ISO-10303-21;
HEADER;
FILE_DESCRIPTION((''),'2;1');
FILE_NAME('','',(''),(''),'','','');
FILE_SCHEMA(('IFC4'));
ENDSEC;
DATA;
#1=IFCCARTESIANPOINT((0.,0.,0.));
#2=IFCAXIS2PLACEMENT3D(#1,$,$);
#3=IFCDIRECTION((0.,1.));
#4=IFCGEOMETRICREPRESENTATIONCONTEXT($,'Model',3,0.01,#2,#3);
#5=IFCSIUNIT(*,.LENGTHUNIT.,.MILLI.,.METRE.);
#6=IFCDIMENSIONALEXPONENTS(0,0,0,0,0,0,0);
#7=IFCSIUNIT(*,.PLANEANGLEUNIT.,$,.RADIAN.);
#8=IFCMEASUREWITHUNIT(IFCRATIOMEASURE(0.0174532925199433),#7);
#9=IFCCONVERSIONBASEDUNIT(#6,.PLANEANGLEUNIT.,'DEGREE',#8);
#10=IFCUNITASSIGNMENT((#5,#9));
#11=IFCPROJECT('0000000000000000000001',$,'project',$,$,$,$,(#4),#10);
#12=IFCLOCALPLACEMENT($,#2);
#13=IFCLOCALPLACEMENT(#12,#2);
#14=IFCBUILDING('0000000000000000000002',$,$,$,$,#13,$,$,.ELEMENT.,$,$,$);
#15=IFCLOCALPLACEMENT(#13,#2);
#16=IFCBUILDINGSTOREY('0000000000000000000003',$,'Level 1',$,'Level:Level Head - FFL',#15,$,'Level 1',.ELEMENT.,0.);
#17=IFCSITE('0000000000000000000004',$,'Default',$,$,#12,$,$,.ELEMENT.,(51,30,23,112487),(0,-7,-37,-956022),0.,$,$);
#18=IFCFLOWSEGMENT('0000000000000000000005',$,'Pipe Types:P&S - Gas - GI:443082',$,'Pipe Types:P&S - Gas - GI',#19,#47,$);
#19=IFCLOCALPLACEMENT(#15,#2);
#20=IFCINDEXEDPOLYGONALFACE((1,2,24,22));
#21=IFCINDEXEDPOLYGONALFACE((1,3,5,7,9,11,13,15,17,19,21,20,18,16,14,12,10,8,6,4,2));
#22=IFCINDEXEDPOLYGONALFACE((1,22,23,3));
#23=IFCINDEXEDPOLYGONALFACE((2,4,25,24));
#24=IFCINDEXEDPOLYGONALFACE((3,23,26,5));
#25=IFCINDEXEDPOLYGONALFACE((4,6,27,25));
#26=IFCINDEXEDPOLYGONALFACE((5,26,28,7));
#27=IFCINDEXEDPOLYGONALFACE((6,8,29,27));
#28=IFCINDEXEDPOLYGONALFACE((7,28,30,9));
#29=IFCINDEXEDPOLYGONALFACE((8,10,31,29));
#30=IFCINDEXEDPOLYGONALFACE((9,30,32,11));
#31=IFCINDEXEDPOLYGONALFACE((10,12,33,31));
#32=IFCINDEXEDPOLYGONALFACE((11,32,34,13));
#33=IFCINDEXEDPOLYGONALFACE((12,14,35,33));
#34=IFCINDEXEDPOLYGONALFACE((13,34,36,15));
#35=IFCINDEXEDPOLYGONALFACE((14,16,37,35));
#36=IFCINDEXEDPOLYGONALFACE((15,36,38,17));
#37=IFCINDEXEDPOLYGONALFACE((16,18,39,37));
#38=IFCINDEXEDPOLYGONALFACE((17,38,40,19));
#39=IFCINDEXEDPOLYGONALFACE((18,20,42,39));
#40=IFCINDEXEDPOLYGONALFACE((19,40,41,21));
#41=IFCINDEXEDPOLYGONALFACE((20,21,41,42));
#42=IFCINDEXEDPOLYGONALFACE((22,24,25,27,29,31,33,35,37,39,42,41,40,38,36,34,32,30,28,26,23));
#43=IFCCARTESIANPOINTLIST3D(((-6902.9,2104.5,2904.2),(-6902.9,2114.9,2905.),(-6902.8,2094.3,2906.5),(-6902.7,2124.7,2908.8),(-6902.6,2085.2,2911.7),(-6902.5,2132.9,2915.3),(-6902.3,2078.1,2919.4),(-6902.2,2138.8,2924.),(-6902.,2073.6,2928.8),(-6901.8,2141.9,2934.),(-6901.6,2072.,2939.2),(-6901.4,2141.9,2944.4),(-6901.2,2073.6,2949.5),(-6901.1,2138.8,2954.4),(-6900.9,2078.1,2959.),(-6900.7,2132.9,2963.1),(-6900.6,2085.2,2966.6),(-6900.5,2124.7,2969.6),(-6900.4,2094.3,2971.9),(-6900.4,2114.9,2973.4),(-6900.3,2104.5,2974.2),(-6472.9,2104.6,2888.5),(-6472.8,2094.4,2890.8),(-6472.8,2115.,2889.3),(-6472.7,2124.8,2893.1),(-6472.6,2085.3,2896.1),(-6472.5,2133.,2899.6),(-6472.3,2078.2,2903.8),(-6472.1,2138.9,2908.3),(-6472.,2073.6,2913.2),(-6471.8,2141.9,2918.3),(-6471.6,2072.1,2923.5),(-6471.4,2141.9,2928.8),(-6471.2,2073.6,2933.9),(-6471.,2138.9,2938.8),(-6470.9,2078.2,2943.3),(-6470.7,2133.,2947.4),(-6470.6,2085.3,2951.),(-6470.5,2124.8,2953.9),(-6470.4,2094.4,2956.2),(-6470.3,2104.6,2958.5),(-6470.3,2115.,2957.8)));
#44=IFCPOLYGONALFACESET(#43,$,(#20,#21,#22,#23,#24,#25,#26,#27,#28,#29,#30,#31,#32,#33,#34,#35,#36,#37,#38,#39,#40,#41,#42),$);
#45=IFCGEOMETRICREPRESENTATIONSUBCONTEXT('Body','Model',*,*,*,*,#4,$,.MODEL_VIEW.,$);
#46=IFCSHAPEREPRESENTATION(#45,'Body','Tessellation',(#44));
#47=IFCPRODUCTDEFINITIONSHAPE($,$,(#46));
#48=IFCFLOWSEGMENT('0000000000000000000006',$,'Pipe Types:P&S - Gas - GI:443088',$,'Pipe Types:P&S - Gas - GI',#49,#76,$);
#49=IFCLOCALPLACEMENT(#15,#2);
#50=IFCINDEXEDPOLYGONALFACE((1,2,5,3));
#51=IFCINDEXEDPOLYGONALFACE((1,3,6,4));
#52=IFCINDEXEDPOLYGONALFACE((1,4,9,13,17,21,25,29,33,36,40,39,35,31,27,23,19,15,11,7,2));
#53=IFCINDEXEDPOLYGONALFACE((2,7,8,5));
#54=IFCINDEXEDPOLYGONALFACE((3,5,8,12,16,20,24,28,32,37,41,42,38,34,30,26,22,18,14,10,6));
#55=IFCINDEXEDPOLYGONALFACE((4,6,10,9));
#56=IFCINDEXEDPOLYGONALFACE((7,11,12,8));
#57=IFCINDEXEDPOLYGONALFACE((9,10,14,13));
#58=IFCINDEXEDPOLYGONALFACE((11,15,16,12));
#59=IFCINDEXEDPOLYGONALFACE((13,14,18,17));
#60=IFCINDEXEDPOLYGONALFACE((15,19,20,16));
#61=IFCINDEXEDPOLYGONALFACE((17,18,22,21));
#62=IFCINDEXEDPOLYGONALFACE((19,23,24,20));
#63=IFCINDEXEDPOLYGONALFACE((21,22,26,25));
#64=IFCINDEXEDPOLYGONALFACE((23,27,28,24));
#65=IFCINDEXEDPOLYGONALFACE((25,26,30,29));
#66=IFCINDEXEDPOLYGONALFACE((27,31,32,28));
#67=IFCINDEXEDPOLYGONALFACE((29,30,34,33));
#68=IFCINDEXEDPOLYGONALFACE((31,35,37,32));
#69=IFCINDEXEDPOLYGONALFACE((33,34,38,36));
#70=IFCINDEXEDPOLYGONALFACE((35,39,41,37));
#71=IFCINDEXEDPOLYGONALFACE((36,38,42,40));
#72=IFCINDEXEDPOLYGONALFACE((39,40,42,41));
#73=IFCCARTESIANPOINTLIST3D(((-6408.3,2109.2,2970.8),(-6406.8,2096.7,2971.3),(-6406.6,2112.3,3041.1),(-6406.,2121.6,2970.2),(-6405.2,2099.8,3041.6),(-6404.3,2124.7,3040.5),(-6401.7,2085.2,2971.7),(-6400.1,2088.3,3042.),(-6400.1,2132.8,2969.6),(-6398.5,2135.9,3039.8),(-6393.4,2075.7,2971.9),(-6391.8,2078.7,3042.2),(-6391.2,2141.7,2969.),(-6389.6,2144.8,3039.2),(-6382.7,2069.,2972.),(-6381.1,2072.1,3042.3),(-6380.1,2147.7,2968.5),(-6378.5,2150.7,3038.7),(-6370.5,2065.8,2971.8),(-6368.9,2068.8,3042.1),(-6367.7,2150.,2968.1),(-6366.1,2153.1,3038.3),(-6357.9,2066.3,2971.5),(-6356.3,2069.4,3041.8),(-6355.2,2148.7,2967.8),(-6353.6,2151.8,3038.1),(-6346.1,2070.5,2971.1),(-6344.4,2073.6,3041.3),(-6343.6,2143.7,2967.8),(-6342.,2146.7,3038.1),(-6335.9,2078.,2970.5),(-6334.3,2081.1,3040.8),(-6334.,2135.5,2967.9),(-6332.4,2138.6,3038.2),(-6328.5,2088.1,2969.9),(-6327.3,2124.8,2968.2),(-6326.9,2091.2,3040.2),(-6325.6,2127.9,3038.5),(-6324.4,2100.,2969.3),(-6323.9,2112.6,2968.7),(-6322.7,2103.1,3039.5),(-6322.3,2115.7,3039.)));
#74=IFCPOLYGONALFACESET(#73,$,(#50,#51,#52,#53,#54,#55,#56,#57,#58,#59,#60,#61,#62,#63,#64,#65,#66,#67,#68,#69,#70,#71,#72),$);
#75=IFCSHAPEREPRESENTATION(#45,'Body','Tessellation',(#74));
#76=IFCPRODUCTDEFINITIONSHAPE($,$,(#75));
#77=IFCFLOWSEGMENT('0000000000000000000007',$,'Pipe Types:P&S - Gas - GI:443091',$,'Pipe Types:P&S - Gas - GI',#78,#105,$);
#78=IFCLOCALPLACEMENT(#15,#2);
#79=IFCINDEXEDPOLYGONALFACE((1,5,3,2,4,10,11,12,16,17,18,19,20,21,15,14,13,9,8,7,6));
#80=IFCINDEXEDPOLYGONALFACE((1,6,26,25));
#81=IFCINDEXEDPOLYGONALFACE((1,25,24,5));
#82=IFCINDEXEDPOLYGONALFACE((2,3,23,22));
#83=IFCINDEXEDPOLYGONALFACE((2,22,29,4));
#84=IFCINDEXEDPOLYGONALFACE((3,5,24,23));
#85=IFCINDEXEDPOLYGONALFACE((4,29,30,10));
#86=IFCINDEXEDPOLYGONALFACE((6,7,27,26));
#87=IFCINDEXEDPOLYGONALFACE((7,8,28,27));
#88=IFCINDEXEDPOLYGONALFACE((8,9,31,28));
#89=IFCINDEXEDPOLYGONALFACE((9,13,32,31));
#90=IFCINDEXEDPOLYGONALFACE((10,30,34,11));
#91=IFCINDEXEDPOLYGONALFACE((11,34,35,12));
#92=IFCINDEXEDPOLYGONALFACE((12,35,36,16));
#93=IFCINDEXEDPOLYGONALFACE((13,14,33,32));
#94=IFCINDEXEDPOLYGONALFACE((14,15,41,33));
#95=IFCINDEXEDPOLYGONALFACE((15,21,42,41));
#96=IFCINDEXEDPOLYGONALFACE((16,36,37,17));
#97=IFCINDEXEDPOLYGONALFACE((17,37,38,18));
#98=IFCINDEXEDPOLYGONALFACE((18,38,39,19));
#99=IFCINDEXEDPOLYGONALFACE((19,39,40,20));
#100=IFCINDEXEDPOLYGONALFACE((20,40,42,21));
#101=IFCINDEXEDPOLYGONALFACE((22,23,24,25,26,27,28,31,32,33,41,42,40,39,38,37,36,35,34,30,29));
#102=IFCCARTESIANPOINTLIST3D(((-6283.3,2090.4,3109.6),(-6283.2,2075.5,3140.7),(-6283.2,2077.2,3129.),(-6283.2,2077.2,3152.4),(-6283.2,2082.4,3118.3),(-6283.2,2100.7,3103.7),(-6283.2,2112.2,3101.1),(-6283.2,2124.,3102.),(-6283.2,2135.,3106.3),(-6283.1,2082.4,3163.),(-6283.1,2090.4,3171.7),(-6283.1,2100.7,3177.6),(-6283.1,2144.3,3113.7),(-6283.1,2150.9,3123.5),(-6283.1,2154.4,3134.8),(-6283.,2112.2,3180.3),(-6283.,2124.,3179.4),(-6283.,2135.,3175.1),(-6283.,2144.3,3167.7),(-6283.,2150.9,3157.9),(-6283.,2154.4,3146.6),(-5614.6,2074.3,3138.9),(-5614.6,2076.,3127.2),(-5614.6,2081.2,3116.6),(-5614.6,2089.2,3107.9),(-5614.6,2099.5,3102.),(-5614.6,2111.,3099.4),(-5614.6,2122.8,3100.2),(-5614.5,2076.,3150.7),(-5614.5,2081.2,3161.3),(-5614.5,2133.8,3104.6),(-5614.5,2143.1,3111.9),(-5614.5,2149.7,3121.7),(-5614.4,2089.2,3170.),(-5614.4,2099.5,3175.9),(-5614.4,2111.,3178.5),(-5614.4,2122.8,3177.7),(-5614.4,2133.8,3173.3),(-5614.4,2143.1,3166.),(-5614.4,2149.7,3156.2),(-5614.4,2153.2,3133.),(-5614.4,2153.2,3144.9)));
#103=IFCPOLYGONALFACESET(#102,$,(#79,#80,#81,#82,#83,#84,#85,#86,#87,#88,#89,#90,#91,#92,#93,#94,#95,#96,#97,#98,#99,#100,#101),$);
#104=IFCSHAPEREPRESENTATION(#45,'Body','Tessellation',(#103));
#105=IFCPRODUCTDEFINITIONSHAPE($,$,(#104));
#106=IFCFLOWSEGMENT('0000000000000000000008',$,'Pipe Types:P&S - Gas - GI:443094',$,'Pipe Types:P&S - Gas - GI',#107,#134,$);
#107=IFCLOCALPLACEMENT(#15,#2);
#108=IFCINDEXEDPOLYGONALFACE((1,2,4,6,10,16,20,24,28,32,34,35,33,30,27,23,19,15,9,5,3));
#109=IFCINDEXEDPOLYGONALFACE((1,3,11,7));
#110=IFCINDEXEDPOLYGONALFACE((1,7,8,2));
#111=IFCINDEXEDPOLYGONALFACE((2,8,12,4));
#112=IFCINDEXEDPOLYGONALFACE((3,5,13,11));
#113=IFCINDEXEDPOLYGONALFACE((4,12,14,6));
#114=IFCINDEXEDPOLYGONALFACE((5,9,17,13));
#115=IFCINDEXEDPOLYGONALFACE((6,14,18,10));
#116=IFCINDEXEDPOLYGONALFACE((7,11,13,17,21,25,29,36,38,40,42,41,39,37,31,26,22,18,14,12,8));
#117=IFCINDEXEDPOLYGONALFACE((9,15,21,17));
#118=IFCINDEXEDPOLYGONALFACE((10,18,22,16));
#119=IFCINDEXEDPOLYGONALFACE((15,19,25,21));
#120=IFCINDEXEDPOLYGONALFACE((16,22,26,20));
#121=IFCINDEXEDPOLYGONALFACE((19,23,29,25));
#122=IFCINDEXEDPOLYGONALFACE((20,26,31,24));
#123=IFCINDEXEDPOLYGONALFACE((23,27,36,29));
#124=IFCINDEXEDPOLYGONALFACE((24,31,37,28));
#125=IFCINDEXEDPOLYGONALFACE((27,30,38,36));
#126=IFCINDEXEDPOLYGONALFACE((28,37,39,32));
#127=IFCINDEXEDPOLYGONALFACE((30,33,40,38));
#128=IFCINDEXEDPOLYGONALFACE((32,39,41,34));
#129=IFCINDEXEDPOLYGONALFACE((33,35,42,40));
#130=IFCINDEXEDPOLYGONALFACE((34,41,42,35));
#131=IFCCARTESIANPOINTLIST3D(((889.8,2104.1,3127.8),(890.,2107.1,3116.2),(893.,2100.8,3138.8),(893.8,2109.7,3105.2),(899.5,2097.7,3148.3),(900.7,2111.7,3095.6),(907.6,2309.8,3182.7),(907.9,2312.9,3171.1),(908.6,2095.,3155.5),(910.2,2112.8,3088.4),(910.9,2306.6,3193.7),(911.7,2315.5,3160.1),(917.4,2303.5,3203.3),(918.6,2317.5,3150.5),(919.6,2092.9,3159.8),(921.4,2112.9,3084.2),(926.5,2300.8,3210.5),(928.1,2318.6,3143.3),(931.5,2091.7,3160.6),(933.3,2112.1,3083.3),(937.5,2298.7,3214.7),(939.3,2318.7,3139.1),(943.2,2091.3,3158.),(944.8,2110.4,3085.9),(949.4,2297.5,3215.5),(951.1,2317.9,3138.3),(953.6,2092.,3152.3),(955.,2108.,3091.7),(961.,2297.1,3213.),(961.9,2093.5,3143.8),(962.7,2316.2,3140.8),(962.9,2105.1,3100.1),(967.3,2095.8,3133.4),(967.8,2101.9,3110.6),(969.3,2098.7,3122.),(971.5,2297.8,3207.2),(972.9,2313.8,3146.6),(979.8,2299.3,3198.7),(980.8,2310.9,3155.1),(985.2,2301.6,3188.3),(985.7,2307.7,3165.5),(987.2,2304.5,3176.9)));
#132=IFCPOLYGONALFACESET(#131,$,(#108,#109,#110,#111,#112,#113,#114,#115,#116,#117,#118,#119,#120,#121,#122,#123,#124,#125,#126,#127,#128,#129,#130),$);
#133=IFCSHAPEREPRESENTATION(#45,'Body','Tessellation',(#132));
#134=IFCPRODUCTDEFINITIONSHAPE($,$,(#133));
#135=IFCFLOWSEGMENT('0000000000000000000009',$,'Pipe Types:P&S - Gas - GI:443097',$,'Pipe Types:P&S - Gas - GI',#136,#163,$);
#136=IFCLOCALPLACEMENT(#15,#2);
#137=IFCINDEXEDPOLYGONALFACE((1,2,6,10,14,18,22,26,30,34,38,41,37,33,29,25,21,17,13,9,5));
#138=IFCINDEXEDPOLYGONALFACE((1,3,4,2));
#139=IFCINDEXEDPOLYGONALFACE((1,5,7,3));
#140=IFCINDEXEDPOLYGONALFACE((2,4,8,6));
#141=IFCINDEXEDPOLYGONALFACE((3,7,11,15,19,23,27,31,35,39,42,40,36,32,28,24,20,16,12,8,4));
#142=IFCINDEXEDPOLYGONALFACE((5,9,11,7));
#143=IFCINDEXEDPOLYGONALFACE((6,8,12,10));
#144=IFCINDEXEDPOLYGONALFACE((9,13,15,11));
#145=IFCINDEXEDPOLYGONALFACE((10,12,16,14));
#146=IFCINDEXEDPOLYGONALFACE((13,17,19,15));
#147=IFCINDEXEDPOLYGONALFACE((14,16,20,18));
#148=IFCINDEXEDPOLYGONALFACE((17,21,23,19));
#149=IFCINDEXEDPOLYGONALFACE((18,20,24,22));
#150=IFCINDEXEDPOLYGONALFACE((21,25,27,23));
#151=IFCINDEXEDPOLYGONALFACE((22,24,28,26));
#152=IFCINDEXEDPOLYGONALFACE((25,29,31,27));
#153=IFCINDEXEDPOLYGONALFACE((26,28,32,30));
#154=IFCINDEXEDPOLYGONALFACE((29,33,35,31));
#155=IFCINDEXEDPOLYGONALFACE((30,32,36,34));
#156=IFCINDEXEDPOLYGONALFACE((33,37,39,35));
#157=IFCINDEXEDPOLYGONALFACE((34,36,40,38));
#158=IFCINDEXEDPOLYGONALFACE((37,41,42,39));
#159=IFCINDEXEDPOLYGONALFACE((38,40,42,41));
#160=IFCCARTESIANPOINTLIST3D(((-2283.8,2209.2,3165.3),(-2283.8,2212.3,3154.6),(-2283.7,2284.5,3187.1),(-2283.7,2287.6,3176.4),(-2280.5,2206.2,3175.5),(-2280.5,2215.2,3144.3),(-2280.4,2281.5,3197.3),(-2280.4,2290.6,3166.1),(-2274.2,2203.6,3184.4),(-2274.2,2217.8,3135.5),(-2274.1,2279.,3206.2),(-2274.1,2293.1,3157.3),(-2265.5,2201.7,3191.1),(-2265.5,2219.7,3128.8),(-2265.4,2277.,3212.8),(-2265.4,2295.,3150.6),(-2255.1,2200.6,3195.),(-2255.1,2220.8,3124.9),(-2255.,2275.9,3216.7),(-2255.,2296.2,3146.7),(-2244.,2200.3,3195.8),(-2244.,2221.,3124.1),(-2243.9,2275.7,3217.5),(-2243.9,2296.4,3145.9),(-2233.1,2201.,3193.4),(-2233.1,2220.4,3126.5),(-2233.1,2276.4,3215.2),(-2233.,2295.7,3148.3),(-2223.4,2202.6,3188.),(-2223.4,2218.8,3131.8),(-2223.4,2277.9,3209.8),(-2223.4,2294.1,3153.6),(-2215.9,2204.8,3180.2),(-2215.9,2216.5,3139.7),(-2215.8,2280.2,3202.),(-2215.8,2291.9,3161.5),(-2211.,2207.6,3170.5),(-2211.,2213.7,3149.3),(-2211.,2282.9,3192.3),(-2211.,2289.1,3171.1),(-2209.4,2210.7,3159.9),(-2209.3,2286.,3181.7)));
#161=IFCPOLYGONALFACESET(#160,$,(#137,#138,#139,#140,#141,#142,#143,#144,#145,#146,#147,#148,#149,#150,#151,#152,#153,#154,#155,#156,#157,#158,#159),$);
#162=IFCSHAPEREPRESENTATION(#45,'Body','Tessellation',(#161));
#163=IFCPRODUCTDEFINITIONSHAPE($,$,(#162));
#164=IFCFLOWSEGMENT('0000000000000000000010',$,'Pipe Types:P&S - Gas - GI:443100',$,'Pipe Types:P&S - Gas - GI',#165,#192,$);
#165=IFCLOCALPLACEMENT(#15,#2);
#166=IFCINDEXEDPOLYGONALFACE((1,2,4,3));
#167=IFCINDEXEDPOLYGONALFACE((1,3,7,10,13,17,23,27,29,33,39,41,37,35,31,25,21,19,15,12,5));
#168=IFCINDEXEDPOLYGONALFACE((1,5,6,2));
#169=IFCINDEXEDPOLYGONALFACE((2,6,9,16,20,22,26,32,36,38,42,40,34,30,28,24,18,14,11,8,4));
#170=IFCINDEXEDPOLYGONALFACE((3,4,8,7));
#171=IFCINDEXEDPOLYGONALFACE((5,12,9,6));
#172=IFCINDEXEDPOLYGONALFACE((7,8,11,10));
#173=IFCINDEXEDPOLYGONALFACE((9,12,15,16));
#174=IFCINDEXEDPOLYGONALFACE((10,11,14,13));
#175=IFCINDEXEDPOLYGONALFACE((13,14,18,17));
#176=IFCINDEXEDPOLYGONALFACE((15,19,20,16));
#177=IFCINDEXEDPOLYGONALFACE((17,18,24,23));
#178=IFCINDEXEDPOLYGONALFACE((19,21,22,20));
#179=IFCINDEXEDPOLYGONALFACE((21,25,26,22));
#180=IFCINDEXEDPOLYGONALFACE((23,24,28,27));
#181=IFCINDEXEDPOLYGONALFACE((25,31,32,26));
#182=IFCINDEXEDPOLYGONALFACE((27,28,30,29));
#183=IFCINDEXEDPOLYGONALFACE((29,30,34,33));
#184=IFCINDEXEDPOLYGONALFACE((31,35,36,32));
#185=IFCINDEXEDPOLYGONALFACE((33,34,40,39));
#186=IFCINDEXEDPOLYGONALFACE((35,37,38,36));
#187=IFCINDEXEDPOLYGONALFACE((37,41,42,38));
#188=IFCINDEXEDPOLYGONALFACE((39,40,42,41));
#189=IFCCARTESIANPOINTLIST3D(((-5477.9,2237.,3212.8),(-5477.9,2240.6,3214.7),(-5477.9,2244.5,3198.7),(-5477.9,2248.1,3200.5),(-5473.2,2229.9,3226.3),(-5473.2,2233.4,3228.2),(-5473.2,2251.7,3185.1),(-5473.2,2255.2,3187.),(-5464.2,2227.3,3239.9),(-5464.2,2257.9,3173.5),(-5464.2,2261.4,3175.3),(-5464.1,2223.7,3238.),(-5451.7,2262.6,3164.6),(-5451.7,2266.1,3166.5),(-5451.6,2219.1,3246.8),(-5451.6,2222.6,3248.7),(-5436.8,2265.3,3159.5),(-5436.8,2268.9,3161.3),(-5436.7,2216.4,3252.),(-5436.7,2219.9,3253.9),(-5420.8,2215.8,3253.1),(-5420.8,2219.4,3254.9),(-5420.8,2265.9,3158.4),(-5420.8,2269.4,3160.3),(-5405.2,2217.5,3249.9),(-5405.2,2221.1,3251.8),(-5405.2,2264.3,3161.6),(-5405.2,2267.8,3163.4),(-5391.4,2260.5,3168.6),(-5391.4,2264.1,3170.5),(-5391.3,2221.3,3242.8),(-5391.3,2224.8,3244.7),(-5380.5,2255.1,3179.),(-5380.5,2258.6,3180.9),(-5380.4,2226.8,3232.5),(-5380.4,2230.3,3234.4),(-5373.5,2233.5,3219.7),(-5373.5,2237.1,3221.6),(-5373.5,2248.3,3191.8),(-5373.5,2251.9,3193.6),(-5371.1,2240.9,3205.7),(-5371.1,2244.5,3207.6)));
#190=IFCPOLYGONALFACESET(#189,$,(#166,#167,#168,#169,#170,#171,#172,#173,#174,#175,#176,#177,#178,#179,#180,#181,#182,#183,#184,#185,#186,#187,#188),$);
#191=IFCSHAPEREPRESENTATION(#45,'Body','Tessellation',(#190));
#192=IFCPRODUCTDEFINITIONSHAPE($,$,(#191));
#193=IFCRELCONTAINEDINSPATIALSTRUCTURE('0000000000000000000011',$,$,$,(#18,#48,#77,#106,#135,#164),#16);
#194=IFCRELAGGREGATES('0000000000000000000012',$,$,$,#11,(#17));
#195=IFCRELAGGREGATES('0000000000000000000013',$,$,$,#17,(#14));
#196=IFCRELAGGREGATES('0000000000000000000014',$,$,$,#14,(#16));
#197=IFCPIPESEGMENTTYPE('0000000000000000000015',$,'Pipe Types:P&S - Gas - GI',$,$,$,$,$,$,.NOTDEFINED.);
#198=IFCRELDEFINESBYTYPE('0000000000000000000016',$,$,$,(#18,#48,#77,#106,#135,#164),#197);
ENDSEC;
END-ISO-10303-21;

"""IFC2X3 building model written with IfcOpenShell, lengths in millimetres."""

from ifc_helpers import new_model, entity, si_unit, converted_unit, direction, frame, frame_2d, origin, origin_2d_with_axis, place, context, subcontext, project, spatial, circle, extrude, type_object, element, save


model = new_model("IFC2X3")

# Units and contexts
model_context = context("Model", 3, precision=0.01, world=origin(), true_north=direction((0.0, 1.0)))
body_context = subcontext(model_context, "Body", "Model", "MODEL_VIEW")
ifc_project = project(units=[si_unit("LENGTHUNIT", "METRE", prefix="MILLI"), converted_unit("PLANEANGLEUNIT", "DEGREE", entity("IfcRatioMeasure", 0.0174532925199433), si_unit("PLANEANGLEUNIT", "RADIAN"), dimensions=[0, 0, 0, 0, 0, 0, 0])], contexts=[model_context])

# Site, building, storey
site_placement = place(None, origin())
site = spatial("IfcSite", under=ifc_project, at=site_placement, Name="Default", CompositionType="ELEMENT", RefLatitude=(51, 30, 23, 112487), RefLongitude=(0, -7, -37, -956022), RefElevation=0.0)
building_placement = place(site_placement, origin())
building = spatial("IfcBuilding", under=site, at=building_placement, CompositionType="ELEMENT")
storey_placement = place(building_placement, origin())
storey = spatial("IfcBuildingStorey", under=building, at=storey_placement, Name="Level 1", ObjectType="Level:Level Head - FFL", LongName="Level 1", CompositionType="ELEMENT", Elevation=0.0)

# Flow segments
pipe_segment_type = type_object("IfcPipeSegmentType", Name="Pipe Types:P&S - Gas - GI", PredefinedType="NOTDEFINED")
flow_segment_1_placement = place(storey_placement, origin())
element("IfcFlowSegment", 1, at=flow_segment_1_placement, inside=storey, type_object=pipe_segment_type, Name="Pipe Types:P&S - Gas - GI:443082", ObjectType="Pipe Types:P&S - Gas - GI", context=body_context, shape_type="SweptSolid", body=[
    extrude(circle(Radius=35.1, at=frame_2d((0.0, 0.0), x_axis=(1.0, 0.0))), frame((-6901.6, 2107.1, 2939.2), z_axis=(0.999337, 0.000168, -0.036403), x_axis=(0.000168, -1.0, 0.0)), (0.0, 0.0, 1.0), 430.3),
])
flow_segment_2_placement = place(storey_placement, origin())
element("IfcFlowSegment", 2, at=flow_segment_2_placement, inside=storey, type_object=pipe_segment_type, Name="Pipe Types:P&S - Gas - GI:443088", ObjectType="Pipe Types:P&S - Gas - GI", context=body_context, shape_type="SweptSolid", body=[
    extrude(circle(Radius=42.3, at=frame_2d((0.0, 0.0), x_axis=(1.0, 0.0))), frame((-6366.0, 2107.8, 2969.9), z_axis=(0.023045, 0.043976, 0.998767), x_axis=(0.885747, -0.464169, 0.0)), (0.0, 0.0, 1.0), 70.4),
])
flow_segment_3_placement = place(storey_placement, origin())
element("IfcFlowSegment", 3, at=flow_segment_3_placement, inside=storey, type_object=pipe_segment_type, Name="Pipe Types:P&S - Gas - GI:443091", ObjectType="Pipe Types:P&S - Gas - GI", context=body_context, shape_type="SweptSolid", body=[
    extrude(circle(Radius=39.7, at=frame_2d((0.0, 0.0), x_axis=(1.0, 0.0))), frame((-5614.5, 2114.0, 3138.9), z_axis=(-0.999995, 0.001805, 0.002594), x_axis=(-0.001805, -0.999998, 0.0)), (0.0, 0.0, 1.0), 668.6),
])
flow_segment_4_placement = place(storey_placement, origin())
element("IfcFlowSegment", 4, at=flow_segment_4_placement, inside=storey, type_object=pipe_segment_type, Name="Pipe Types:P&S - Gas - GI:443094", ObjectType="Pipe Types:P&S - Gas - GI", context=body_context, shape_type="SweptSolid", body=[
    extrude(circle(Radius=40.1, at=origin_2d_with_axis()), frame((929.4, 2102.2, 3122.0), z_axis=(0.083676, 0.962792, 0.256962), x_axis=(0.996245, -0.086584, 0.0)), (0.0, 0.0, 1.0), 213.7),
])
flow_segment_5_placement = place(storey_placement, origin())
element("IfcFlowSegment", 5, at=flow_segment_5_placement, inside=storey, type_object=pipe_segment_type, Name="Pipe Types:P&S - Gas - GI:443097", ObjectType="Pipe Types:P&S - Gas - GI", context=body_context, shape_type="SweptSolid", body=[
    extrude(circle(Radius=37.4, at=frame_2d((0.0, 0.0), x_axis=(1.0, 0.0))), frame((-2246.8, 2210.7, 3159.9), z_axis=(0.000645, 0.960668, 0.277697), x_axis=(1.0, -0.000671, 0.0)), (0.0, 0.0, 1.0), 78.4),
])
flow_segment_6_placement = place(storey_placement, origin())
element("IfcFlowSegment", 6, at=flow_segment_6_placement, inside=storey, type_object=pipe_segment_type, Name="Pipe Types:P&S - Gas - GI:443100", ObjectType="Pipe Types:P&S - Gas - GI", context=body_context, shape_type="SweptSolid", body=[
    extrude(circle(Radius=53.7, at=frame_2d((0.0, 0.0), x_axis=(1.0, 0.0))), frame((-5424.8, 2240.9, 3205.7), z_axis=(-0.001336, 0.884012, 0.467462), x_axis=(0.999999, 0.001511, 0.0)), (0.0, 0.0, 1.0), 4.0),
])

save(model, "model.ifc")
